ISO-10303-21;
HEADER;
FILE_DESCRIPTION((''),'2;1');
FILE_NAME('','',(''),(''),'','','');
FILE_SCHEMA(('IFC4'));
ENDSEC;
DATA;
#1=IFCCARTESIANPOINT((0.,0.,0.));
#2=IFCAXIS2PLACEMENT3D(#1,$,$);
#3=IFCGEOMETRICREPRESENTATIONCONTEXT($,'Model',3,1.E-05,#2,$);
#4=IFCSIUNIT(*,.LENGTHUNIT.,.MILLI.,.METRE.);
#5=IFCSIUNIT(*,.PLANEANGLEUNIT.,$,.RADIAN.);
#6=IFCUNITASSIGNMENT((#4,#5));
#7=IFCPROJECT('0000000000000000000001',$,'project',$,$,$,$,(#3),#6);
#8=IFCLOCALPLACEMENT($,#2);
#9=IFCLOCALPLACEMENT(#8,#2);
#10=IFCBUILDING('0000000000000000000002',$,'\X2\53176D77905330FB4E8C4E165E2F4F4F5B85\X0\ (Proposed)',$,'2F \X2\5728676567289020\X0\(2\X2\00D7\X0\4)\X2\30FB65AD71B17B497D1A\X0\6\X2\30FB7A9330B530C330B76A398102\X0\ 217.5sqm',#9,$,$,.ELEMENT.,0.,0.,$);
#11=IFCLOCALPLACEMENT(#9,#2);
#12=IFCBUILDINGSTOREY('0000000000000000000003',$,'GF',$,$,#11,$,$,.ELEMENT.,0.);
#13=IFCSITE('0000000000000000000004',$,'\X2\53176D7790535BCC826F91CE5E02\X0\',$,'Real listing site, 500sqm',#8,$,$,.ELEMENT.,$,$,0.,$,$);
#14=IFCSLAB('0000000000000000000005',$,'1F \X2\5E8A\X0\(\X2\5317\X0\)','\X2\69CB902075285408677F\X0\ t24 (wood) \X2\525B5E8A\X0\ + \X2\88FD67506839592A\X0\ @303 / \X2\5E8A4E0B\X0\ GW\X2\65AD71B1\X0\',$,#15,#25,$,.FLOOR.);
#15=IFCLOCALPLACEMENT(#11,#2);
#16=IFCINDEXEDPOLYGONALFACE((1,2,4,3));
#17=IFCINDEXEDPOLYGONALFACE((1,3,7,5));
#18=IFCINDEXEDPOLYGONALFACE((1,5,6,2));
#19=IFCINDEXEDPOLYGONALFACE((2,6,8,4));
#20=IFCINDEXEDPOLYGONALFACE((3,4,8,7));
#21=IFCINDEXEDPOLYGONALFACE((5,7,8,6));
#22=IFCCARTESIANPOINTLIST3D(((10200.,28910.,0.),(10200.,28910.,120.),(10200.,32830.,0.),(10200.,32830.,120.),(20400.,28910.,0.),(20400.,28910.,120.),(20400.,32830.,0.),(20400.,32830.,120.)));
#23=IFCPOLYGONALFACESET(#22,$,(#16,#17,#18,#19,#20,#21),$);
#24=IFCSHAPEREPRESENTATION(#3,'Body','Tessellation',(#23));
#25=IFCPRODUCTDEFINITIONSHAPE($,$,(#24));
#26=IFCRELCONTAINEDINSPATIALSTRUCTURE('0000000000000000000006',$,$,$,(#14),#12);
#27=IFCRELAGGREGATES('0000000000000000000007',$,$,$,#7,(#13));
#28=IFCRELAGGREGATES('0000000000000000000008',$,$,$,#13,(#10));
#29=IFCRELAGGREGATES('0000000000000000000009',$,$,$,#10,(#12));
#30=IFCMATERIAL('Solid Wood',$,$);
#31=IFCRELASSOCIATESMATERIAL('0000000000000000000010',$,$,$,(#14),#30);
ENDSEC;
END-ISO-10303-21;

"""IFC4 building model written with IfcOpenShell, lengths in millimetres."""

from ifc_helpers import new_model, si_unit, frame, frame_2d, origin, place, context, project, spatial, rectangle, extrude, material, element, save


model = new_model("IFC4")

# Units and contexts
model_context = context("Model", 3, precision=1e-05, world=origin())
ifc_project = project(units=[si_unit("LENGTHUNIT", "METRE", prefix="MILLI"), si_unit("PLANEANGLEUNIT", "RADIAN")], contexts=[model_context])

# Site, building, storey
site_placement = place(None, origin())
site = spatial("IfcSite", under=ifc_project, at=site_placement, Name="北海道富良野市", ObjectType="Real listing site, 500sqm", CompositionType="ELEMENT", RefElevation=0.0)
building_placement = place(site_placement, origin())
building = spatial("IfcBuilding", under=site, at=building_placement, Name="北海道・二世帯住宅 (Proposed)", ObjectType="2F 在来木造(2×4)・断熱等級6・窓サッシ樹脂 217.5sqm", CompositionType="ELEMENT", ElevationOfRefHeight=0.0, ElevationOfTerrain=0.0)
storey_placement = place(building_placement, origin())
storey = spatial("IfcBuildingStorey", under=building, at=storey_placement, Name="GF", CompositionType="ELEMENT", Elevation=0.0)

# Shared definitions
ifc_material_1 = material(Name="Solid Wood")

# Slab
slab_1_placement = place(storey_placement, frame((5100.0, 14455.0, 0.0)))
element("IfcSlab", 1, at=slab_1_placement, inside=storey, material=ifc_material_1, Name="1F 床(北)", Description="構造用合板 t24 (wood) 剛床 + 製材根太 @303 / 床下 GW断熱", PredefinedType="FLOOR", context=model_context, shape_type="SweptSolid", body=[
    extrude(rectangle(XDim=10200.0, YDim=3920.0, at=frame_2d((5100.0, 1960.0))), frame((5100.0, 14455.0, 0.0)), (0.0, 0.0, 1.0), 120.0),
])

save(model, "model.ifc")
